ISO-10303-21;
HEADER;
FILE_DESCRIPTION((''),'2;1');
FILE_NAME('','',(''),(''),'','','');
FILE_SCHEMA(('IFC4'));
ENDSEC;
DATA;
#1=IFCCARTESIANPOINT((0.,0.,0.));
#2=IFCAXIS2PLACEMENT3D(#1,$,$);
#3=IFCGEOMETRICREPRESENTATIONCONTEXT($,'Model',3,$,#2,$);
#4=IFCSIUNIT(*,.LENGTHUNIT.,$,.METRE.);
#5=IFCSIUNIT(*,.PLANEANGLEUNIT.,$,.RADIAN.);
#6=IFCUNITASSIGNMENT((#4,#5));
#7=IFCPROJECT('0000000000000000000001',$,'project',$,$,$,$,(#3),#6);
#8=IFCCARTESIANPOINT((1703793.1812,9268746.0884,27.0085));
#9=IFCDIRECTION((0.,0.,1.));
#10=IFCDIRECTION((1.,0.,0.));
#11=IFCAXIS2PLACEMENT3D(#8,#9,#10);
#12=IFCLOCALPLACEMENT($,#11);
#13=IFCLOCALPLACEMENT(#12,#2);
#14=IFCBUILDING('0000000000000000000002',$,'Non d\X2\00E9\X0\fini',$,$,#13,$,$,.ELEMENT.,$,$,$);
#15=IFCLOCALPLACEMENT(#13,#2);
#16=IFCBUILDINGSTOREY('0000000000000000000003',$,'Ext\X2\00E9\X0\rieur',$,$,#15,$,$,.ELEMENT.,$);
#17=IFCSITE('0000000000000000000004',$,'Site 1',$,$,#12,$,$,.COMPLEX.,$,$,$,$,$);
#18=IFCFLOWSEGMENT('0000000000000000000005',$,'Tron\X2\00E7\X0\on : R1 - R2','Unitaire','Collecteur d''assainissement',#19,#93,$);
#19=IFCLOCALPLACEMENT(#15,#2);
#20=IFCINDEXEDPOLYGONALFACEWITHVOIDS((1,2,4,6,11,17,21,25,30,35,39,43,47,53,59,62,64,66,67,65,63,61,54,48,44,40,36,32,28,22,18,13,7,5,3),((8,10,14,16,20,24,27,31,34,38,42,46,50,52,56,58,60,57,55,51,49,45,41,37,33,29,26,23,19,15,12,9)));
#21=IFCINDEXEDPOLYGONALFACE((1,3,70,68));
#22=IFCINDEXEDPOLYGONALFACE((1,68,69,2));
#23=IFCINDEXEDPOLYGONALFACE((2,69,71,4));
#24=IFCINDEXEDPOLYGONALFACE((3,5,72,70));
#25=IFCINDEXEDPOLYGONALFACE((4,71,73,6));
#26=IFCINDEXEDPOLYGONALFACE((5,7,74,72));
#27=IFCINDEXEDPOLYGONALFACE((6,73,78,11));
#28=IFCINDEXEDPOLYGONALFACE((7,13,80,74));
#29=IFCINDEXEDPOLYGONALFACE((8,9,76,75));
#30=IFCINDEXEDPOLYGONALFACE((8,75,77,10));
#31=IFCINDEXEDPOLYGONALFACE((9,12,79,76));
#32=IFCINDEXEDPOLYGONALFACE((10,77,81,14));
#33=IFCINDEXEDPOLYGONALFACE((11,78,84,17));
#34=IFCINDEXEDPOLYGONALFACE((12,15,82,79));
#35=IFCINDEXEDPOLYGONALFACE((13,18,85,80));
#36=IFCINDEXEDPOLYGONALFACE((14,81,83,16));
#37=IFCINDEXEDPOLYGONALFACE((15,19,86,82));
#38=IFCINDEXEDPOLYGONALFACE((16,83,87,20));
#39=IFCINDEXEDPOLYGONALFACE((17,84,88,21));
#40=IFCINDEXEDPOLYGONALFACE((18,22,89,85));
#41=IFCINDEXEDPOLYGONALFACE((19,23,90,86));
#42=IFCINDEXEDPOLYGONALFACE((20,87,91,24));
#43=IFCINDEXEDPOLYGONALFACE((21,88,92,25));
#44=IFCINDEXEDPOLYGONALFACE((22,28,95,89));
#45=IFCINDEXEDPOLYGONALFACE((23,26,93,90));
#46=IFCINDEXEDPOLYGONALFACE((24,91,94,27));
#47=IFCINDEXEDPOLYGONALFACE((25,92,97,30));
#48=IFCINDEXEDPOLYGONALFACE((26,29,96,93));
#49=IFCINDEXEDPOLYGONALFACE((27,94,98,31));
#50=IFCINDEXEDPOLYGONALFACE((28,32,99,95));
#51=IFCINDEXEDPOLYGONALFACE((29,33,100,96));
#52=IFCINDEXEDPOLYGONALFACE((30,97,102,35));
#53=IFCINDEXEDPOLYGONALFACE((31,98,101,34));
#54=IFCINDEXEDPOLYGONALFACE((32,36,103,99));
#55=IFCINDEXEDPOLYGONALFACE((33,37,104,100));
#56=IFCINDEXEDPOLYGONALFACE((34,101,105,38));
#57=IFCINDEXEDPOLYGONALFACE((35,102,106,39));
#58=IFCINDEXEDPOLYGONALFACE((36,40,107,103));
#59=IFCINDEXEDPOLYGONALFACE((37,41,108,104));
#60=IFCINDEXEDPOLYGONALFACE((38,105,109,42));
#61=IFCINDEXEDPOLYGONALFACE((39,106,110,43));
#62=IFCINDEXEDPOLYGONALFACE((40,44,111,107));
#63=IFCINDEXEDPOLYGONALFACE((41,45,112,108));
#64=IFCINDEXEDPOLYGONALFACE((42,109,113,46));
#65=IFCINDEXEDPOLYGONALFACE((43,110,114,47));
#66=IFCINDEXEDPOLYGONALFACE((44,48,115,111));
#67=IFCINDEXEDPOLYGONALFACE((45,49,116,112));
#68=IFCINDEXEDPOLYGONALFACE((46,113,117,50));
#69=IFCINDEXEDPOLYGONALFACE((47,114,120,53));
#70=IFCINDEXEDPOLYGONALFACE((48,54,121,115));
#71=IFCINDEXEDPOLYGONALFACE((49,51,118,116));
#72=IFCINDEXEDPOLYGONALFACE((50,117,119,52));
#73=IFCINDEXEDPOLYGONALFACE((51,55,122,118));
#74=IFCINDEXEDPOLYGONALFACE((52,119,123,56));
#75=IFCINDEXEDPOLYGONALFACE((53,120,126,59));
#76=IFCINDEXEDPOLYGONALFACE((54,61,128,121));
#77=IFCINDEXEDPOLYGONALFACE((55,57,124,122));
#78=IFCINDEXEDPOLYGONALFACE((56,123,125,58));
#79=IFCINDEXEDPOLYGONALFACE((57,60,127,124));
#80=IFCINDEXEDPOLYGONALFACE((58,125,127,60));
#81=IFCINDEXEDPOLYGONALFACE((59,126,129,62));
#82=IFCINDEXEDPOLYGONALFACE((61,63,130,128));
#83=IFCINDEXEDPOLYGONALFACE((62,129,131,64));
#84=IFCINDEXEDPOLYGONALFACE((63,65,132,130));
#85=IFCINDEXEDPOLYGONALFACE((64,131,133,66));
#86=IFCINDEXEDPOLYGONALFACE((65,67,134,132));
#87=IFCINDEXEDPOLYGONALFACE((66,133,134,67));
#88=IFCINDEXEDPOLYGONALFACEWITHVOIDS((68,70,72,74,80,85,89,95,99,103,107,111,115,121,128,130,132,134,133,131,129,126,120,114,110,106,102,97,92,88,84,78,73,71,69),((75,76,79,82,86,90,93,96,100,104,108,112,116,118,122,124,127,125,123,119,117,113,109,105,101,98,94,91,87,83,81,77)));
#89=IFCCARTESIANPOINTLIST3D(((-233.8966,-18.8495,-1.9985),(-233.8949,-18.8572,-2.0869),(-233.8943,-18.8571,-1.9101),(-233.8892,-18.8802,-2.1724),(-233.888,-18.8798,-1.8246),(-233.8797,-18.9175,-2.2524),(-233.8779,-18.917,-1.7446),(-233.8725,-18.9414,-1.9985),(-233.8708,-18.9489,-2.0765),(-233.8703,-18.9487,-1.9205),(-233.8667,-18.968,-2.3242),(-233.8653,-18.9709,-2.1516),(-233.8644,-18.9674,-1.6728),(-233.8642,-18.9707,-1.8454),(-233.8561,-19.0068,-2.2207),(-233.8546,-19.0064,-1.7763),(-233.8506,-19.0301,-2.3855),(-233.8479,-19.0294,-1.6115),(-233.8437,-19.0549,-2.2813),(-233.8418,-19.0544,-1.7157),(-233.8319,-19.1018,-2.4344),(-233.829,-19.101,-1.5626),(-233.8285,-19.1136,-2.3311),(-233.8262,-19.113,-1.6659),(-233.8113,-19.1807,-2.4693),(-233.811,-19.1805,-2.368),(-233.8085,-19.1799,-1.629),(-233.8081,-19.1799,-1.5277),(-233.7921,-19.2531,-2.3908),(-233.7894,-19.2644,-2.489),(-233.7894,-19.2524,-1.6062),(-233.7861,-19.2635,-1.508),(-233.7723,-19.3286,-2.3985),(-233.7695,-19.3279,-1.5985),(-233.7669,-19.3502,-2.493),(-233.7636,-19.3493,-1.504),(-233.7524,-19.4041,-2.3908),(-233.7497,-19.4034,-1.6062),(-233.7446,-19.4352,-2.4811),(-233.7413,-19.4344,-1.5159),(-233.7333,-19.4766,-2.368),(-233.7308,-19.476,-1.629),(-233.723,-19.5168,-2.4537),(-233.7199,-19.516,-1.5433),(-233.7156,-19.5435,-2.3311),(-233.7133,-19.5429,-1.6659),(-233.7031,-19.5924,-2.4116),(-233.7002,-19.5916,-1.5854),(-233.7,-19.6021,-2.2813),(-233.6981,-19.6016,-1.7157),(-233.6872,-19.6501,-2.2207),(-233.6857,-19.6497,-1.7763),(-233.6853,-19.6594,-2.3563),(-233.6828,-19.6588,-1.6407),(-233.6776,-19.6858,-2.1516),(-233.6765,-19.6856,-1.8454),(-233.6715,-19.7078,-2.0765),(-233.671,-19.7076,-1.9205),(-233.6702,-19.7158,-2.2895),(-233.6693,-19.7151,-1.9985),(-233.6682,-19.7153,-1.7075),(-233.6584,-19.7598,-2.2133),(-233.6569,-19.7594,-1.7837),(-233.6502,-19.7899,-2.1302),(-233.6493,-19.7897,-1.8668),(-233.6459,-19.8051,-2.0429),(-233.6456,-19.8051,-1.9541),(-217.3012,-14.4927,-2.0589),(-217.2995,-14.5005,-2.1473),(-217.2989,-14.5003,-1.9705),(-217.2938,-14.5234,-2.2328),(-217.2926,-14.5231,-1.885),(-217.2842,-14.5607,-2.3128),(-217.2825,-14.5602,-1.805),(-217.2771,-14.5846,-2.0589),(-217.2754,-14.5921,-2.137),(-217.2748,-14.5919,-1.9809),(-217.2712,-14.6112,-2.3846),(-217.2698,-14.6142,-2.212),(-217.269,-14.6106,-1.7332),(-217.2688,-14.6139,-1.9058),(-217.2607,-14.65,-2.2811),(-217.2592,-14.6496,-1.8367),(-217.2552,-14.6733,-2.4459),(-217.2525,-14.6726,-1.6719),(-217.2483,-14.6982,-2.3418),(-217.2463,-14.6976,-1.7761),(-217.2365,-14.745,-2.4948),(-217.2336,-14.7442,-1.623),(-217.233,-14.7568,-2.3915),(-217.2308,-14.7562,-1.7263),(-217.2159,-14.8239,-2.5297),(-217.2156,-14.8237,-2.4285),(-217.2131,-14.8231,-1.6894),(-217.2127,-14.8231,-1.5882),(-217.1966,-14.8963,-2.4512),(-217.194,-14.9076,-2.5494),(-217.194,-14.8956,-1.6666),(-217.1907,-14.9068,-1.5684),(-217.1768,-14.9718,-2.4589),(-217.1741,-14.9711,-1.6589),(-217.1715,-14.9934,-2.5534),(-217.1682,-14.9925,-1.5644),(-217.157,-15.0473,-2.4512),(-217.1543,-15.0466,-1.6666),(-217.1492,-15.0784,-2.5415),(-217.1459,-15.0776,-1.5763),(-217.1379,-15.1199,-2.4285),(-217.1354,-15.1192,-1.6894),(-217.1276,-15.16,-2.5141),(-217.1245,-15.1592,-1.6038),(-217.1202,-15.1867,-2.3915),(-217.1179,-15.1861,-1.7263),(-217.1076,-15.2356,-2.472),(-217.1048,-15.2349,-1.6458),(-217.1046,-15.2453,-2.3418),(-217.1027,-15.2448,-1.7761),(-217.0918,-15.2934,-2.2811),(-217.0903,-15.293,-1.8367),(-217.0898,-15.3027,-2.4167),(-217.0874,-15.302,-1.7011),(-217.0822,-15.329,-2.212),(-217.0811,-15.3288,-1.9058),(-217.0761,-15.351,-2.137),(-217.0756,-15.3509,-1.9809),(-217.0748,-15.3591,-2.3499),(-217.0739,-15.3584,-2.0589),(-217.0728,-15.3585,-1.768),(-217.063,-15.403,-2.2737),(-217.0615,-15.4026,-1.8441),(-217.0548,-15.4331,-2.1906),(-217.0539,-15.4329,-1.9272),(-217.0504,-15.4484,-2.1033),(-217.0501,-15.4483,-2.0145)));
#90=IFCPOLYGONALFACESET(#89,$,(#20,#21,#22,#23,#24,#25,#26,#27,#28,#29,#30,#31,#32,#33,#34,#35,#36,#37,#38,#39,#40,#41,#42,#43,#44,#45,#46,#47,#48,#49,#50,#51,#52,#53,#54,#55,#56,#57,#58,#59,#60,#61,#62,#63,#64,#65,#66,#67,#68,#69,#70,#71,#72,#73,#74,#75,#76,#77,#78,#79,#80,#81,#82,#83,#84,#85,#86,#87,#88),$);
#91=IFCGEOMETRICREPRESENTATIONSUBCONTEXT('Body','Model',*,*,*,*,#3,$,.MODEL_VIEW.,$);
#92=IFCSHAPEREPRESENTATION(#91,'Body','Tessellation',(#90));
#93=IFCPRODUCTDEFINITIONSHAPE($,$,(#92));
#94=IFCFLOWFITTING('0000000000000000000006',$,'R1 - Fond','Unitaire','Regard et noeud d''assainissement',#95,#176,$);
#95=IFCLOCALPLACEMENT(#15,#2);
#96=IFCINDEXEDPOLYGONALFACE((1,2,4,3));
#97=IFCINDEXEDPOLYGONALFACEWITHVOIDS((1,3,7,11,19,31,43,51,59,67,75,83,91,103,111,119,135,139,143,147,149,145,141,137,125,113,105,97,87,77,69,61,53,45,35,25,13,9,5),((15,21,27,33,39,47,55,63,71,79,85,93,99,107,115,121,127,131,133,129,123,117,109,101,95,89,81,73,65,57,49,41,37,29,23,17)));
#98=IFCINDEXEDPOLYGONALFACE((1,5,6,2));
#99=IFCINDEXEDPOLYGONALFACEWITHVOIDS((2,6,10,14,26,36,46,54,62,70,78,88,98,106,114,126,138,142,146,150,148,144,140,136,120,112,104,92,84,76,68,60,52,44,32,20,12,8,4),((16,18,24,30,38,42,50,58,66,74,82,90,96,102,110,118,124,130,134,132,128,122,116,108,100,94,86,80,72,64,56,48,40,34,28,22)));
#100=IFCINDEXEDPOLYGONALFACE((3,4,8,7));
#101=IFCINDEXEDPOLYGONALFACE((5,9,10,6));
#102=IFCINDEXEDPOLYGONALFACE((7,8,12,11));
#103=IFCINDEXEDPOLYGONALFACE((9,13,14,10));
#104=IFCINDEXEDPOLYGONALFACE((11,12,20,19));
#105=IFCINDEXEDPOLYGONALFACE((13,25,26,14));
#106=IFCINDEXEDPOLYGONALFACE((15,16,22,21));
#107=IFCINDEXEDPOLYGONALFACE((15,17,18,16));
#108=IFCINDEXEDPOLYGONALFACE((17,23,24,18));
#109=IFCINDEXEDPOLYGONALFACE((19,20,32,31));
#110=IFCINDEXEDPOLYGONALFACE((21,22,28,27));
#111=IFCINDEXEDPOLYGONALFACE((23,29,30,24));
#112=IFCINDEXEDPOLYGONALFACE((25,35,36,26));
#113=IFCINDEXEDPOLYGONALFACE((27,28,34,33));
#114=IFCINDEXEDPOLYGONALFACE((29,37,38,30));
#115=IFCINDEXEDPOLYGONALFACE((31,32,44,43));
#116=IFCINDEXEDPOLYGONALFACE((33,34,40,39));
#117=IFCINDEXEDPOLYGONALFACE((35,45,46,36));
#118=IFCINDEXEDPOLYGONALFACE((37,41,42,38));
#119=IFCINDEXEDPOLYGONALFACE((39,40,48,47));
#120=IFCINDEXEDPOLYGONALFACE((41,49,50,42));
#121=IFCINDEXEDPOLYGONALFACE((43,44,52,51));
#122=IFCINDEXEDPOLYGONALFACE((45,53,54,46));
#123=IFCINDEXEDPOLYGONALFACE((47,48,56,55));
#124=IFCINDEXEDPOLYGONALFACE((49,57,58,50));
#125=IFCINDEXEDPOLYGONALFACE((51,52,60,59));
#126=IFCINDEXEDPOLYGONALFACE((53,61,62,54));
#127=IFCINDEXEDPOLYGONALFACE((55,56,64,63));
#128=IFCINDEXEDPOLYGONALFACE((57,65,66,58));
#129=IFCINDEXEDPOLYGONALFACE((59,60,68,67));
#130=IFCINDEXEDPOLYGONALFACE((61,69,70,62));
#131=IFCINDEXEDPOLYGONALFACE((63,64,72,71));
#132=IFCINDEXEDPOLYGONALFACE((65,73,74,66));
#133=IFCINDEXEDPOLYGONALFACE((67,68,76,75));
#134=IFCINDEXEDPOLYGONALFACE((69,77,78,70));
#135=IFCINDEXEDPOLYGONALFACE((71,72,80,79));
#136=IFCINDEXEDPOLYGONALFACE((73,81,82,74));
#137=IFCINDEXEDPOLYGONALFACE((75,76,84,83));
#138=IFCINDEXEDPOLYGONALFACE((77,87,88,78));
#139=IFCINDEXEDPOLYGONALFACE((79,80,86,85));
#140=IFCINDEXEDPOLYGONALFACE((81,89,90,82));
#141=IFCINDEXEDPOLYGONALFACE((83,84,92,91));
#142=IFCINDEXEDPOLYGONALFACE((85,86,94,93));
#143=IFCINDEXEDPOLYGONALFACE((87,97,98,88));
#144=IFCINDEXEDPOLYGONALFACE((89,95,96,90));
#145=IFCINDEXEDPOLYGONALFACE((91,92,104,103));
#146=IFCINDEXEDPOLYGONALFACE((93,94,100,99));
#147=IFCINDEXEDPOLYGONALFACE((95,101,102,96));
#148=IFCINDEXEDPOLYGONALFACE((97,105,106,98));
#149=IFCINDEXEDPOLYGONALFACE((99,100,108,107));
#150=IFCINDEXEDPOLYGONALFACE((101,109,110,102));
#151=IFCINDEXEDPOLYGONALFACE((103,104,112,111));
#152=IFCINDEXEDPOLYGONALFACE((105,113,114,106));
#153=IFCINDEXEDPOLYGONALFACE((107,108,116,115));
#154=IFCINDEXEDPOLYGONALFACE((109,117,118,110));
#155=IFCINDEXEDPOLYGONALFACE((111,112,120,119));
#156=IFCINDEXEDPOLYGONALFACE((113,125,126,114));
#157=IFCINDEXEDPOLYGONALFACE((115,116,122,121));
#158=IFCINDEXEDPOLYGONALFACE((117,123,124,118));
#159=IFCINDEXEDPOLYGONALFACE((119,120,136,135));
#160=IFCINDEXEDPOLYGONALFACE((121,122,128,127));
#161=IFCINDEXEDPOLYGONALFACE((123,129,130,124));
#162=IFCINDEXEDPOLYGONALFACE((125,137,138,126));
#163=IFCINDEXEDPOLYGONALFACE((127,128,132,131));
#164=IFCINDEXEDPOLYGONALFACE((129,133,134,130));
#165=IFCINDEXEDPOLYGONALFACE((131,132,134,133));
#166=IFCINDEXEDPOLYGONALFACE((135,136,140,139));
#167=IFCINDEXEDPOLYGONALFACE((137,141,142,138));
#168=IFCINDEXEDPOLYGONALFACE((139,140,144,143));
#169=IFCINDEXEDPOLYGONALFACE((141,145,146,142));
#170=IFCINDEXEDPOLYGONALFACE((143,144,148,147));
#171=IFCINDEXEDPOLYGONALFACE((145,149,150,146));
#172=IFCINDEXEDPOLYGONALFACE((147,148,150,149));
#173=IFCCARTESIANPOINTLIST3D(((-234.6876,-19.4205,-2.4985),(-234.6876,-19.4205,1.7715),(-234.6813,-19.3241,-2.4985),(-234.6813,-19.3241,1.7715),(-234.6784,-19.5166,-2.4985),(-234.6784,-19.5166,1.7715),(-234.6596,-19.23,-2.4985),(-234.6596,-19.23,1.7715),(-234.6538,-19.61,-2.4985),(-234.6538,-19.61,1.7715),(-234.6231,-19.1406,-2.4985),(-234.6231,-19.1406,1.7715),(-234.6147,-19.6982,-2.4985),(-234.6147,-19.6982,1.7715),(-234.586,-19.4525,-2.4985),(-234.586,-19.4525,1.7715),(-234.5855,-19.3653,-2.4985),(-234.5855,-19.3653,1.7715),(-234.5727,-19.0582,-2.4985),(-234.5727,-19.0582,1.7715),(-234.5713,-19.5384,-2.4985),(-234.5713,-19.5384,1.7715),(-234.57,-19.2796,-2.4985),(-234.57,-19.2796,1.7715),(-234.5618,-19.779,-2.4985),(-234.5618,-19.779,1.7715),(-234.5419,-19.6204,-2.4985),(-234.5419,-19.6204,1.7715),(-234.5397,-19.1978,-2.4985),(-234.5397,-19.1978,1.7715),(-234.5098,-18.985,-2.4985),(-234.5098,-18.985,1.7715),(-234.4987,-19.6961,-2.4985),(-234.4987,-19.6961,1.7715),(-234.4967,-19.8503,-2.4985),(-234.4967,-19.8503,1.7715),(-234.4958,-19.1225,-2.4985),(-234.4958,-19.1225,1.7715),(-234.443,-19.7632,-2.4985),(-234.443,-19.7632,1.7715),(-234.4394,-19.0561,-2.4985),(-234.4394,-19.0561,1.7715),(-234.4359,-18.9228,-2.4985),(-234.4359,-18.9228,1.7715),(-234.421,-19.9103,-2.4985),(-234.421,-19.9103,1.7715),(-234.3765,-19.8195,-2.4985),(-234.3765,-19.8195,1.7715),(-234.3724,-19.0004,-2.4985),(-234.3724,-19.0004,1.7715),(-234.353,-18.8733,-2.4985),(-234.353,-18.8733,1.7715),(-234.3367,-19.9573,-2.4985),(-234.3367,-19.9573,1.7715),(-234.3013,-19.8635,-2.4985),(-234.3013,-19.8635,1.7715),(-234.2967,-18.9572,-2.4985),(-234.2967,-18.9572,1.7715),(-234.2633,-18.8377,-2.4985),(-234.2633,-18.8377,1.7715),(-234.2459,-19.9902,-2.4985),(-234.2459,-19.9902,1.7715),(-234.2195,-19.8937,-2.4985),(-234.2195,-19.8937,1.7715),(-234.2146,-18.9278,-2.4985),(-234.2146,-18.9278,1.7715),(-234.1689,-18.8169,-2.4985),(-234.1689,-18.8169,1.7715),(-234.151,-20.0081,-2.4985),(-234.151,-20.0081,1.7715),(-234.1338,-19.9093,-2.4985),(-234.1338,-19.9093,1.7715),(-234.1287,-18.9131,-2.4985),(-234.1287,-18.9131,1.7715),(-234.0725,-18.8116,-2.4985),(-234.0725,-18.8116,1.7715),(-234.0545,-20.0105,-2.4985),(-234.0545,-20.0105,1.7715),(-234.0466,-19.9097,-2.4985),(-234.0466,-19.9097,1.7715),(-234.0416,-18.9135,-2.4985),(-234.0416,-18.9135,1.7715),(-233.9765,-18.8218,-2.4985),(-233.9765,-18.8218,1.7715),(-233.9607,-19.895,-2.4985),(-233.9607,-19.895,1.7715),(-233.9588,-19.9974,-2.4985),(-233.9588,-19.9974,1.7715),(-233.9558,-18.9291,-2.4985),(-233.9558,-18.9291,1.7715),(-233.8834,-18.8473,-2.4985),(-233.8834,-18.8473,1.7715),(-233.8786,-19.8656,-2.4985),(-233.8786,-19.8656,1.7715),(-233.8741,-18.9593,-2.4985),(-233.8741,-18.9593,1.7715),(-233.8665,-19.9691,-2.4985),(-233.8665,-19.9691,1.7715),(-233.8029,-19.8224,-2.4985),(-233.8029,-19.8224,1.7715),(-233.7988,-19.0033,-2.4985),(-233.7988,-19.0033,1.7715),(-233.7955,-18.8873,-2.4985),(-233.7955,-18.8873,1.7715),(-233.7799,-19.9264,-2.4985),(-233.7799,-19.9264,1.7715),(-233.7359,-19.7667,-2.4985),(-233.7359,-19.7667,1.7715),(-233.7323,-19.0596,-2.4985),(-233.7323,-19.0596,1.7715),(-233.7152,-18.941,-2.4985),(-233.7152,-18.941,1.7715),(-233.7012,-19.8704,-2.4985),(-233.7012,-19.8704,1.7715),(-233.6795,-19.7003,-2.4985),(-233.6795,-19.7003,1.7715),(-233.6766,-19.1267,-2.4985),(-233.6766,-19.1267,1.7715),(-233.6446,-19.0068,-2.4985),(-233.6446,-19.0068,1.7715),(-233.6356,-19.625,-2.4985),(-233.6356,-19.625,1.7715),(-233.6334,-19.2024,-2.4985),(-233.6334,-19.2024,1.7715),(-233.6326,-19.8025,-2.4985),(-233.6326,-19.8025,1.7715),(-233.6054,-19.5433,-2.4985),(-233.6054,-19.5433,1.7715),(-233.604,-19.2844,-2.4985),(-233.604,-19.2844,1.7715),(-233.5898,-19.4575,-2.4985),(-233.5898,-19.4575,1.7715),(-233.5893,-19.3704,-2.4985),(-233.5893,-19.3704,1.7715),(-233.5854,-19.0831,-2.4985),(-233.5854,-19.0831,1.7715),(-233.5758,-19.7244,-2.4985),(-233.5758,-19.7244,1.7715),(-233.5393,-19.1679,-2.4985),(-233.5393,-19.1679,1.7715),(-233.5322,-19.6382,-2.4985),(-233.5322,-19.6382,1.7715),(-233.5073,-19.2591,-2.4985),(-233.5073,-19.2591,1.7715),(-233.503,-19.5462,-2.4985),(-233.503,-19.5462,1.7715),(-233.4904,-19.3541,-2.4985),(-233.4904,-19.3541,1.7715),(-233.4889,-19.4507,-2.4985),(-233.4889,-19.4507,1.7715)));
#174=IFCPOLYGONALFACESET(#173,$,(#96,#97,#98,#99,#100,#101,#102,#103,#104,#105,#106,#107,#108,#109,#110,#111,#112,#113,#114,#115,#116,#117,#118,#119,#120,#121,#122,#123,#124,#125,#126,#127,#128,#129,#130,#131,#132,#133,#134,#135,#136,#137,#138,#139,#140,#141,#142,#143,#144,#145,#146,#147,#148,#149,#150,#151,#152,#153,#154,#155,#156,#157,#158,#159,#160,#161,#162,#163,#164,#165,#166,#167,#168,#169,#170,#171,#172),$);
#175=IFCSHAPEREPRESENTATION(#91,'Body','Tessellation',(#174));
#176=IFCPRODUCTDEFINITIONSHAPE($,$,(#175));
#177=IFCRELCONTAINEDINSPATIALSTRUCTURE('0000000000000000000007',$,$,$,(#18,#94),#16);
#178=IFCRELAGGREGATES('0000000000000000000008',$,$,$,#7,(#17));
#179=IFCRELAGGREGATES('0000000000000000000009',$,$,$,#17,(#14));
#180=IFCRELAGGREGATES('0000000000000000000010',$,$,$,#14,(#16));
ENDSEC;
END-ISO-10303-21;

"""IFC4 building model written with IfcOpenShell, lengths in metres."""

from ifc_helpers import new_model, si_unit, frame, origin, origin_2d, place, context, subcontext, project, spatial, hollow_circle, extrude, element, save


model = new_model("IFC4")

# Units and contexts
model_context = context("Model", 3, world=origin())
body_context = subcontext(model_context, "Body", "Model", "MODEL_VIEW")
ifc_project = project(units=[si_unit("LENGTHUNIT", "METRE"), si_unit("PLANEANGLEUNIT", "RADIAN")], contexts=[model_context])

# Site, building, storey
site_placement = place(None, frame((1703793.1812, 9268746.0884, 27.0085), z_axis=(0.0, 0.0, 1.0), x_axis=(1.0, 0.0, 0.0)))
site = spatial("IfcSite", under=ifc_project, at=site_placement, Name="Site 1", CompositionType="COMPLEX")
building_placement = place(site_placement, origin())
building = spatial("IfcBuilding", under=site, at=building_placement, Name="Non défini", CompositionType="ELEMENT")
storey_placement = place(building_placement, origin())
storey = spatial("IfcBuildingStorey", under=building, at=storey_placement, Name="Extérieur", CompositionType="ELEMENT")

# Flow segment
flow_segment_1_placement = place(storey_placement, origin())
element("IfcFlowSegment", 1, at=flow_segment_1_placement, inside=storey, Name="Tronçon : R1 - R2", Description="Unitaire", ObjectType="Collecteur d'assainissement", context=body_context, shape_type="SweptSolid", body=[
    extrude(hollow_circle(Radius=0.495, WallThickness=0.095, at=origin_2d()), frame((-233.7709, -19.3283, -1.9985), z_axis=(0.967218, 0.253923, -0.003521), x_axis=(-0.253924, 0.967224, 0.0)), (0.0, 0.0, 1.0), 17.1579),
])

# Flow fitting
flow_fitting_1_placement = place(storey_placement, origin())
element("IfcFlowFitting", 2, at=flow_fitting_1_placement, inside=storey, Name="R1 - Fond", Description="Unitaire", ObjectType="Regard et noeud d'assainissement", context=body_context, shape_type="SweptSolid", body=[
    extrude(hollow_circle(Radius=0.6, WallThickness=0.1, at=origin_2d()), frame((-234.0877, -19.4114, -2.4985), z_axis=(0.0, 0.0, 1.0), x_axis=(0.967224, 0.253924, 0.0)), (0.0, 0.0, 1.0), 4.27),
])

save(model, "model.ifc")
